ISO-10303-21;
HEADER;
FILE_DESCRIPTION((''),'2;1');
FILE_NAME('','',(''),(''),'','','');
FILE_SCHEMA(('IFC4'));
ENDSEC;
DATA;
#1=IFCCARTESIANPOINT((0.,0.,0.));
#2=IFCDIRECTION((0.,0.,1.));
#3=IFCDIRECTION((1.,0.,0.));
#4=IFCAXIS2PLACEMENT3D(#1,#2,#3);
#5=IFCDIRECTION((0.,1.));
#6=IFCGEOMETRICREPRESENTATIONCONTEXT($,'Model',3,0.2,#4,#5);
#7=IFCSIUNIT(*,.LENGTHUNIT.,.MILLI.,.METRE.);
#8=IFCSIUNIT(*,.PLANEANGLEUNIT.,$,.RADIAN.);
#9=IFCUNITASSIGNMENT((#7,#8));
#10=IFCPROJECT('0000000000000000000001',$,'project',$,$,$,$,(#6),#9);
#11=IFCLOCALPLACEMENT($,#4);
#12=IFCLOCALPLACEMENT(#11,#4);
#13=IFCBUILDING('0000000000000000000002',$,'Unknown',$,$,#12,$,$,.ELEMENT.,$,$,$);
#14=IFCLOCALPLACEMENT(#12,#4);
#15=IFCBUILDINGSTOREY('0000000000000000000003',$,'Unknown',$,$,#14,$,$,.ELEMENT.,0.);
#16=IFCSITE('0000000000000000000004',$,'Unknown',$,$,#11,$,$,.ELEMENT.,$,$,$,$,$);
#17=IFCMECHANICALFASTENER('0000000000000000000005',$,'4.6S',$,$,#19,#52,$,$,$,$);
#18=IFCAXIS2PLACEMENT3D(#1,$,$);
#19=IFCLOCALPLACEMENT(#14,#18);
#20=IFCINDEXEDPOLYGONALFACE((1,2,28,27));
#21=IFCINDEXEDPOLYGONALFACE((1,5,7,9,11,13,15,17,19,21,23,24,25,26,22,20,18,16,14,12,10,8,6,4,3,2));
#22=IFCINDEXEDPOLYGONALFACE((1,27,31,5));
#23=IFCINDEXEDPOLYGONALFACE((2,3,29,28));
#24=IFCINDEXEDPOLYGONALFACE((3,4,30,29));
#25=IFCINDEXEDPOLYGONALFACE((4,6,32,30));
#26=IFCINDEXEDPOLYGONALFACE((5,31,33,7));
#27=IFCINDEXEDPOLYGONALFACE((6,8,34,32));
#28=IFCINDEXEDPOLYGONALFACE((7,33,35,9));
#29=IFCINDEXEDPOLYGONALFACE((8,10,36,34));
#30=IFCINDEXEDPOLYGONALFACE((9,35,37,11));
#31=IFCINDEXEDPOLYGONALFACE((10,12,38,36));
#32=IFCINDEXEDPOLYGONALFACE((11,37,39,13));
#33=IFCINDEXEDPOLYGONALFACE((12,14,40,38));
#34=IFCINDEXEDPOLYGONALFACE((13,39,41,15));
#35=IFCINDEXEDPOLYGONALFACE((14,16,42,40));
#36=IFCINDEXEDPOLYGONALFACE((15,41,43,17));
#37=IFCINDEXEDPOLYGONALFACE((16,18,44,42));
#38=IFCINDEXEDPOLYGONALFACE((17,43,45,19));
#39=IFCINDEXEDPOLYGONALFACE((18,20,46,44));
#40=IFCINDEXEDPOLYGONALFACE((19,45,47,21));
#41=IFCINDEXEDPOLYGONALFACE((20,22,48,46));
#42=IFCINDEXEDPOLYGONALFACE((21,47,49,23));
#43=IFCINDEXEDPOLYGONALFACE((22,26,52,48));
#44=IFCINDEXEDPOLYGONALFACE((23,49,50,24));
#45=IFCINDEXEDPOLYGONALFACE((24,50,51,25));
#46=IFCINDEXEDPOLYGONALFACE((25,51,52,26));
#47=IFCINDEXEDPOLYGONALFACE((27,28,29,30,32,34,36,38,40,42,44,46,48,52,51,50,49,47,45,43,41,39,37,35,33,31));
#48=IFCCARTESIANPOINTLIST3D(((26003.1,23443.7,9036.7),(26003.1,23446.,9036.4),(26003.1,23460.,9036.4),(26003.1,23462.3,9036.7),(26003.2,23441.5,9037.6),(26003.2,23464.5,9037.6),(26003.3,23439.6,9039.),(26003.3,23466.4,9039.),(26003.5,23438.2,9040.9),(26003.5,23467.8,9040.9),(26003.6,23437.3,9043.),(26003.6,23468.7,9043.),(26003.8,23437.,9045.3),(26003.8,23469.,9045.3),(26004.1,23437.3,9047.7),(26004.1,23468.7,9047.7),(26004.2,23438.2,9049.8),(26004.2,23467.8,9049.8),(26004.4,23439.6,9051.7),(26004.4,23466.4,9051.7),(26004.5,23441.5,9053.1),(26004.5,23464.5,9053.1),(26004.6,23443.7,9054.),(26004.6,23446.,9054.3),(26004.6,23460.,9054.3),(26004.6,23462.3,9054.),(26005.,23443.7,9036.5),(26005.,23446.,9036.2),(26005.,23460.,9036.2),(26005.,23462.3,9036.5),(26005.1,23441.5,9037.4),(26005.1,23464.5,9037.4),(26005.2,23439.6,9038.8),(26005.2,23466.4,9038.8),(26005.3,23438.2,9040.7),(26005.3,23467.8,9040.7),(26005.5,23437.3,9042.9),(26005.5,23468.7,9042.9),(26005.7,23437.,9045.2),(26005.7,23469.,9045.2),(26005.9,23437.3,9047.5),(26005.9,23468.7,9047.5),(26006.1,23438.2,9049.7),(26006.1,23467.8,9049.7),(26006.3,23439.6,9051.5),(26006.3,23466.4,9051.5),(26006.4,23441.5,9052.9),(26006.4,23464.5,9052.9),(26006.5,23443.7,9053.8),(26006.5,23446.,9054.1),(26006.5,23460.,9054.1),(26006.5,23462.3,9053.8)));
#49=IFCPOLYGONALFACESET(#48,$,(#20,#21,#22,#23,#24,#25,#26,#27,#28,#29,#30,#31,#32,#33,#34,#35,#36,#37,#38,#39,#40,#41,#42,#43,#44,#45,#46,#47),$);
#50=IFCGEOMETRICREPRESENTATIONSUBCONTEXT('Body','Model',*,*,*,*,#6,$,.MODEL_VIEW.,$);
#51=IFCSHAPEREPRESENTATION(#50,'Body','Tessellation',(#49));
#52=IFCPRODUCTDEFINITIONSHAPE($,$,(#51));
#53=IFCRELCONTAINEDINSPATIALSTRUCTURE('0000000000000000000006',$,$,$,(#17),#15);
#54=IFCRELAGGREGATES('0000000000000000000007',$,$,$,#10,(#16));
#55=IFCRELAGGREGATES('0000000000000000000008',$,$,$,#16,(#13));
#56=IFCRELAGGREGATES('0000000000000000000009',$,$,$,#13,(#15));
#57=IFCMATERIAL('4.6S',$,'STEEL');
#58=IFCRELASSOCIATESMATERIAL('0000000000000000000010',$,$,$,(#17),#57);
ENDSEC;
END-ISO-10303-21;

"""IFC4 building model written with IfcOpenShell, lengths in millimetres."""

from ifc_helpers import new_model, si_unit, direction, frame, origin_with_axes, place, context, subcontext, project, spatial, line, arc, indexed_curve, outline, extrude, source, transform, mapped, material, element, save


model = new_model("IFC4")

# Units and contexts
model_context = context("Model", 3, precision=0.2, world=origin_with_axes(), true_north=direction((0.0, 1.0)))
body_context = subcontext(model_context, "Body", "Model", "MODEL_VIEW")
ifc_project = project(units=[si_unit("LENGTHUNIT", "METRE", prefix="MILLI"), si_unit("PLANEANGLEUNIT", "RADIAN")], contexts=[model_context])

# Site, building, storey
site_placement = place(None, origin_with_axes())
site = spatial("IfcSite", under=ifc_project, at=site_placement, Name="Unknown", CompositionType="ELEMENT")
building_placement = place(site_placement, origin_with_axes())
building = spatial("IfcBuilding", under=site, at=building_placement, Name="Unknown", CompositionType="ELEMENT")
storey_placement = place(building_placement, origin_with_axes())
storey = spatial("IfcBuildingStorey", under=building, at=storey_placement, Name="Unknown", CompositionType="ELEMENT", Elevation=0.0)

# Mechanical fastener
ifc_material_1 = material(Name="4.6S", Category="STEEL")
shared_shape_1 = source(origin_with_axes(), body_context, "Body", "SweptSolid", [
    extrude(outline(indexed_curve([(-7.0, 9.0), (7.0, 9.0), (7.0, 9.0), (13.4, 6.4), (16.0, 0.0), (13.4, -6.4), (7.0, -9.0), (-7.0, -9.0), (-7.8, -9.0), (-16.0, 0.0), (-13.4, 6.4)], segments=[line(1, 2, 3), arc(3, 4, 5), arc(5, 6, 7), line(7, 8), arc(8, 9, 10), arc(10, 11, 1)])), frame((0.0, 0.0, 0.9), z_axis=(0.0, 0.0, -1.0), x_axis=(0.0, 1.0, 0.0)), (0.0, 0.0, 1.0), 1.9),
])
for number, where, z_axis, x_axis, name in (
    (1, (26004.8, 23453.0, 9045.3), (-0.996195, 0.0, 0.087156), (0.087156, 0.0, 0.996195), "4.6S"),
):
    element("IfcMechanicalFastener", number, at=place(storey_placement, frame(where, z_axis=z_axis, x_axis=x_axis)), inside=storey, material=ifc_material_1, Name=name, context=body_context, shape_type="MappedRepresentation", body=[
        mapped(shared_shape_1, transform((0.0, 0.0, 0.0))),
    ])

save(model, "model.ifc")
